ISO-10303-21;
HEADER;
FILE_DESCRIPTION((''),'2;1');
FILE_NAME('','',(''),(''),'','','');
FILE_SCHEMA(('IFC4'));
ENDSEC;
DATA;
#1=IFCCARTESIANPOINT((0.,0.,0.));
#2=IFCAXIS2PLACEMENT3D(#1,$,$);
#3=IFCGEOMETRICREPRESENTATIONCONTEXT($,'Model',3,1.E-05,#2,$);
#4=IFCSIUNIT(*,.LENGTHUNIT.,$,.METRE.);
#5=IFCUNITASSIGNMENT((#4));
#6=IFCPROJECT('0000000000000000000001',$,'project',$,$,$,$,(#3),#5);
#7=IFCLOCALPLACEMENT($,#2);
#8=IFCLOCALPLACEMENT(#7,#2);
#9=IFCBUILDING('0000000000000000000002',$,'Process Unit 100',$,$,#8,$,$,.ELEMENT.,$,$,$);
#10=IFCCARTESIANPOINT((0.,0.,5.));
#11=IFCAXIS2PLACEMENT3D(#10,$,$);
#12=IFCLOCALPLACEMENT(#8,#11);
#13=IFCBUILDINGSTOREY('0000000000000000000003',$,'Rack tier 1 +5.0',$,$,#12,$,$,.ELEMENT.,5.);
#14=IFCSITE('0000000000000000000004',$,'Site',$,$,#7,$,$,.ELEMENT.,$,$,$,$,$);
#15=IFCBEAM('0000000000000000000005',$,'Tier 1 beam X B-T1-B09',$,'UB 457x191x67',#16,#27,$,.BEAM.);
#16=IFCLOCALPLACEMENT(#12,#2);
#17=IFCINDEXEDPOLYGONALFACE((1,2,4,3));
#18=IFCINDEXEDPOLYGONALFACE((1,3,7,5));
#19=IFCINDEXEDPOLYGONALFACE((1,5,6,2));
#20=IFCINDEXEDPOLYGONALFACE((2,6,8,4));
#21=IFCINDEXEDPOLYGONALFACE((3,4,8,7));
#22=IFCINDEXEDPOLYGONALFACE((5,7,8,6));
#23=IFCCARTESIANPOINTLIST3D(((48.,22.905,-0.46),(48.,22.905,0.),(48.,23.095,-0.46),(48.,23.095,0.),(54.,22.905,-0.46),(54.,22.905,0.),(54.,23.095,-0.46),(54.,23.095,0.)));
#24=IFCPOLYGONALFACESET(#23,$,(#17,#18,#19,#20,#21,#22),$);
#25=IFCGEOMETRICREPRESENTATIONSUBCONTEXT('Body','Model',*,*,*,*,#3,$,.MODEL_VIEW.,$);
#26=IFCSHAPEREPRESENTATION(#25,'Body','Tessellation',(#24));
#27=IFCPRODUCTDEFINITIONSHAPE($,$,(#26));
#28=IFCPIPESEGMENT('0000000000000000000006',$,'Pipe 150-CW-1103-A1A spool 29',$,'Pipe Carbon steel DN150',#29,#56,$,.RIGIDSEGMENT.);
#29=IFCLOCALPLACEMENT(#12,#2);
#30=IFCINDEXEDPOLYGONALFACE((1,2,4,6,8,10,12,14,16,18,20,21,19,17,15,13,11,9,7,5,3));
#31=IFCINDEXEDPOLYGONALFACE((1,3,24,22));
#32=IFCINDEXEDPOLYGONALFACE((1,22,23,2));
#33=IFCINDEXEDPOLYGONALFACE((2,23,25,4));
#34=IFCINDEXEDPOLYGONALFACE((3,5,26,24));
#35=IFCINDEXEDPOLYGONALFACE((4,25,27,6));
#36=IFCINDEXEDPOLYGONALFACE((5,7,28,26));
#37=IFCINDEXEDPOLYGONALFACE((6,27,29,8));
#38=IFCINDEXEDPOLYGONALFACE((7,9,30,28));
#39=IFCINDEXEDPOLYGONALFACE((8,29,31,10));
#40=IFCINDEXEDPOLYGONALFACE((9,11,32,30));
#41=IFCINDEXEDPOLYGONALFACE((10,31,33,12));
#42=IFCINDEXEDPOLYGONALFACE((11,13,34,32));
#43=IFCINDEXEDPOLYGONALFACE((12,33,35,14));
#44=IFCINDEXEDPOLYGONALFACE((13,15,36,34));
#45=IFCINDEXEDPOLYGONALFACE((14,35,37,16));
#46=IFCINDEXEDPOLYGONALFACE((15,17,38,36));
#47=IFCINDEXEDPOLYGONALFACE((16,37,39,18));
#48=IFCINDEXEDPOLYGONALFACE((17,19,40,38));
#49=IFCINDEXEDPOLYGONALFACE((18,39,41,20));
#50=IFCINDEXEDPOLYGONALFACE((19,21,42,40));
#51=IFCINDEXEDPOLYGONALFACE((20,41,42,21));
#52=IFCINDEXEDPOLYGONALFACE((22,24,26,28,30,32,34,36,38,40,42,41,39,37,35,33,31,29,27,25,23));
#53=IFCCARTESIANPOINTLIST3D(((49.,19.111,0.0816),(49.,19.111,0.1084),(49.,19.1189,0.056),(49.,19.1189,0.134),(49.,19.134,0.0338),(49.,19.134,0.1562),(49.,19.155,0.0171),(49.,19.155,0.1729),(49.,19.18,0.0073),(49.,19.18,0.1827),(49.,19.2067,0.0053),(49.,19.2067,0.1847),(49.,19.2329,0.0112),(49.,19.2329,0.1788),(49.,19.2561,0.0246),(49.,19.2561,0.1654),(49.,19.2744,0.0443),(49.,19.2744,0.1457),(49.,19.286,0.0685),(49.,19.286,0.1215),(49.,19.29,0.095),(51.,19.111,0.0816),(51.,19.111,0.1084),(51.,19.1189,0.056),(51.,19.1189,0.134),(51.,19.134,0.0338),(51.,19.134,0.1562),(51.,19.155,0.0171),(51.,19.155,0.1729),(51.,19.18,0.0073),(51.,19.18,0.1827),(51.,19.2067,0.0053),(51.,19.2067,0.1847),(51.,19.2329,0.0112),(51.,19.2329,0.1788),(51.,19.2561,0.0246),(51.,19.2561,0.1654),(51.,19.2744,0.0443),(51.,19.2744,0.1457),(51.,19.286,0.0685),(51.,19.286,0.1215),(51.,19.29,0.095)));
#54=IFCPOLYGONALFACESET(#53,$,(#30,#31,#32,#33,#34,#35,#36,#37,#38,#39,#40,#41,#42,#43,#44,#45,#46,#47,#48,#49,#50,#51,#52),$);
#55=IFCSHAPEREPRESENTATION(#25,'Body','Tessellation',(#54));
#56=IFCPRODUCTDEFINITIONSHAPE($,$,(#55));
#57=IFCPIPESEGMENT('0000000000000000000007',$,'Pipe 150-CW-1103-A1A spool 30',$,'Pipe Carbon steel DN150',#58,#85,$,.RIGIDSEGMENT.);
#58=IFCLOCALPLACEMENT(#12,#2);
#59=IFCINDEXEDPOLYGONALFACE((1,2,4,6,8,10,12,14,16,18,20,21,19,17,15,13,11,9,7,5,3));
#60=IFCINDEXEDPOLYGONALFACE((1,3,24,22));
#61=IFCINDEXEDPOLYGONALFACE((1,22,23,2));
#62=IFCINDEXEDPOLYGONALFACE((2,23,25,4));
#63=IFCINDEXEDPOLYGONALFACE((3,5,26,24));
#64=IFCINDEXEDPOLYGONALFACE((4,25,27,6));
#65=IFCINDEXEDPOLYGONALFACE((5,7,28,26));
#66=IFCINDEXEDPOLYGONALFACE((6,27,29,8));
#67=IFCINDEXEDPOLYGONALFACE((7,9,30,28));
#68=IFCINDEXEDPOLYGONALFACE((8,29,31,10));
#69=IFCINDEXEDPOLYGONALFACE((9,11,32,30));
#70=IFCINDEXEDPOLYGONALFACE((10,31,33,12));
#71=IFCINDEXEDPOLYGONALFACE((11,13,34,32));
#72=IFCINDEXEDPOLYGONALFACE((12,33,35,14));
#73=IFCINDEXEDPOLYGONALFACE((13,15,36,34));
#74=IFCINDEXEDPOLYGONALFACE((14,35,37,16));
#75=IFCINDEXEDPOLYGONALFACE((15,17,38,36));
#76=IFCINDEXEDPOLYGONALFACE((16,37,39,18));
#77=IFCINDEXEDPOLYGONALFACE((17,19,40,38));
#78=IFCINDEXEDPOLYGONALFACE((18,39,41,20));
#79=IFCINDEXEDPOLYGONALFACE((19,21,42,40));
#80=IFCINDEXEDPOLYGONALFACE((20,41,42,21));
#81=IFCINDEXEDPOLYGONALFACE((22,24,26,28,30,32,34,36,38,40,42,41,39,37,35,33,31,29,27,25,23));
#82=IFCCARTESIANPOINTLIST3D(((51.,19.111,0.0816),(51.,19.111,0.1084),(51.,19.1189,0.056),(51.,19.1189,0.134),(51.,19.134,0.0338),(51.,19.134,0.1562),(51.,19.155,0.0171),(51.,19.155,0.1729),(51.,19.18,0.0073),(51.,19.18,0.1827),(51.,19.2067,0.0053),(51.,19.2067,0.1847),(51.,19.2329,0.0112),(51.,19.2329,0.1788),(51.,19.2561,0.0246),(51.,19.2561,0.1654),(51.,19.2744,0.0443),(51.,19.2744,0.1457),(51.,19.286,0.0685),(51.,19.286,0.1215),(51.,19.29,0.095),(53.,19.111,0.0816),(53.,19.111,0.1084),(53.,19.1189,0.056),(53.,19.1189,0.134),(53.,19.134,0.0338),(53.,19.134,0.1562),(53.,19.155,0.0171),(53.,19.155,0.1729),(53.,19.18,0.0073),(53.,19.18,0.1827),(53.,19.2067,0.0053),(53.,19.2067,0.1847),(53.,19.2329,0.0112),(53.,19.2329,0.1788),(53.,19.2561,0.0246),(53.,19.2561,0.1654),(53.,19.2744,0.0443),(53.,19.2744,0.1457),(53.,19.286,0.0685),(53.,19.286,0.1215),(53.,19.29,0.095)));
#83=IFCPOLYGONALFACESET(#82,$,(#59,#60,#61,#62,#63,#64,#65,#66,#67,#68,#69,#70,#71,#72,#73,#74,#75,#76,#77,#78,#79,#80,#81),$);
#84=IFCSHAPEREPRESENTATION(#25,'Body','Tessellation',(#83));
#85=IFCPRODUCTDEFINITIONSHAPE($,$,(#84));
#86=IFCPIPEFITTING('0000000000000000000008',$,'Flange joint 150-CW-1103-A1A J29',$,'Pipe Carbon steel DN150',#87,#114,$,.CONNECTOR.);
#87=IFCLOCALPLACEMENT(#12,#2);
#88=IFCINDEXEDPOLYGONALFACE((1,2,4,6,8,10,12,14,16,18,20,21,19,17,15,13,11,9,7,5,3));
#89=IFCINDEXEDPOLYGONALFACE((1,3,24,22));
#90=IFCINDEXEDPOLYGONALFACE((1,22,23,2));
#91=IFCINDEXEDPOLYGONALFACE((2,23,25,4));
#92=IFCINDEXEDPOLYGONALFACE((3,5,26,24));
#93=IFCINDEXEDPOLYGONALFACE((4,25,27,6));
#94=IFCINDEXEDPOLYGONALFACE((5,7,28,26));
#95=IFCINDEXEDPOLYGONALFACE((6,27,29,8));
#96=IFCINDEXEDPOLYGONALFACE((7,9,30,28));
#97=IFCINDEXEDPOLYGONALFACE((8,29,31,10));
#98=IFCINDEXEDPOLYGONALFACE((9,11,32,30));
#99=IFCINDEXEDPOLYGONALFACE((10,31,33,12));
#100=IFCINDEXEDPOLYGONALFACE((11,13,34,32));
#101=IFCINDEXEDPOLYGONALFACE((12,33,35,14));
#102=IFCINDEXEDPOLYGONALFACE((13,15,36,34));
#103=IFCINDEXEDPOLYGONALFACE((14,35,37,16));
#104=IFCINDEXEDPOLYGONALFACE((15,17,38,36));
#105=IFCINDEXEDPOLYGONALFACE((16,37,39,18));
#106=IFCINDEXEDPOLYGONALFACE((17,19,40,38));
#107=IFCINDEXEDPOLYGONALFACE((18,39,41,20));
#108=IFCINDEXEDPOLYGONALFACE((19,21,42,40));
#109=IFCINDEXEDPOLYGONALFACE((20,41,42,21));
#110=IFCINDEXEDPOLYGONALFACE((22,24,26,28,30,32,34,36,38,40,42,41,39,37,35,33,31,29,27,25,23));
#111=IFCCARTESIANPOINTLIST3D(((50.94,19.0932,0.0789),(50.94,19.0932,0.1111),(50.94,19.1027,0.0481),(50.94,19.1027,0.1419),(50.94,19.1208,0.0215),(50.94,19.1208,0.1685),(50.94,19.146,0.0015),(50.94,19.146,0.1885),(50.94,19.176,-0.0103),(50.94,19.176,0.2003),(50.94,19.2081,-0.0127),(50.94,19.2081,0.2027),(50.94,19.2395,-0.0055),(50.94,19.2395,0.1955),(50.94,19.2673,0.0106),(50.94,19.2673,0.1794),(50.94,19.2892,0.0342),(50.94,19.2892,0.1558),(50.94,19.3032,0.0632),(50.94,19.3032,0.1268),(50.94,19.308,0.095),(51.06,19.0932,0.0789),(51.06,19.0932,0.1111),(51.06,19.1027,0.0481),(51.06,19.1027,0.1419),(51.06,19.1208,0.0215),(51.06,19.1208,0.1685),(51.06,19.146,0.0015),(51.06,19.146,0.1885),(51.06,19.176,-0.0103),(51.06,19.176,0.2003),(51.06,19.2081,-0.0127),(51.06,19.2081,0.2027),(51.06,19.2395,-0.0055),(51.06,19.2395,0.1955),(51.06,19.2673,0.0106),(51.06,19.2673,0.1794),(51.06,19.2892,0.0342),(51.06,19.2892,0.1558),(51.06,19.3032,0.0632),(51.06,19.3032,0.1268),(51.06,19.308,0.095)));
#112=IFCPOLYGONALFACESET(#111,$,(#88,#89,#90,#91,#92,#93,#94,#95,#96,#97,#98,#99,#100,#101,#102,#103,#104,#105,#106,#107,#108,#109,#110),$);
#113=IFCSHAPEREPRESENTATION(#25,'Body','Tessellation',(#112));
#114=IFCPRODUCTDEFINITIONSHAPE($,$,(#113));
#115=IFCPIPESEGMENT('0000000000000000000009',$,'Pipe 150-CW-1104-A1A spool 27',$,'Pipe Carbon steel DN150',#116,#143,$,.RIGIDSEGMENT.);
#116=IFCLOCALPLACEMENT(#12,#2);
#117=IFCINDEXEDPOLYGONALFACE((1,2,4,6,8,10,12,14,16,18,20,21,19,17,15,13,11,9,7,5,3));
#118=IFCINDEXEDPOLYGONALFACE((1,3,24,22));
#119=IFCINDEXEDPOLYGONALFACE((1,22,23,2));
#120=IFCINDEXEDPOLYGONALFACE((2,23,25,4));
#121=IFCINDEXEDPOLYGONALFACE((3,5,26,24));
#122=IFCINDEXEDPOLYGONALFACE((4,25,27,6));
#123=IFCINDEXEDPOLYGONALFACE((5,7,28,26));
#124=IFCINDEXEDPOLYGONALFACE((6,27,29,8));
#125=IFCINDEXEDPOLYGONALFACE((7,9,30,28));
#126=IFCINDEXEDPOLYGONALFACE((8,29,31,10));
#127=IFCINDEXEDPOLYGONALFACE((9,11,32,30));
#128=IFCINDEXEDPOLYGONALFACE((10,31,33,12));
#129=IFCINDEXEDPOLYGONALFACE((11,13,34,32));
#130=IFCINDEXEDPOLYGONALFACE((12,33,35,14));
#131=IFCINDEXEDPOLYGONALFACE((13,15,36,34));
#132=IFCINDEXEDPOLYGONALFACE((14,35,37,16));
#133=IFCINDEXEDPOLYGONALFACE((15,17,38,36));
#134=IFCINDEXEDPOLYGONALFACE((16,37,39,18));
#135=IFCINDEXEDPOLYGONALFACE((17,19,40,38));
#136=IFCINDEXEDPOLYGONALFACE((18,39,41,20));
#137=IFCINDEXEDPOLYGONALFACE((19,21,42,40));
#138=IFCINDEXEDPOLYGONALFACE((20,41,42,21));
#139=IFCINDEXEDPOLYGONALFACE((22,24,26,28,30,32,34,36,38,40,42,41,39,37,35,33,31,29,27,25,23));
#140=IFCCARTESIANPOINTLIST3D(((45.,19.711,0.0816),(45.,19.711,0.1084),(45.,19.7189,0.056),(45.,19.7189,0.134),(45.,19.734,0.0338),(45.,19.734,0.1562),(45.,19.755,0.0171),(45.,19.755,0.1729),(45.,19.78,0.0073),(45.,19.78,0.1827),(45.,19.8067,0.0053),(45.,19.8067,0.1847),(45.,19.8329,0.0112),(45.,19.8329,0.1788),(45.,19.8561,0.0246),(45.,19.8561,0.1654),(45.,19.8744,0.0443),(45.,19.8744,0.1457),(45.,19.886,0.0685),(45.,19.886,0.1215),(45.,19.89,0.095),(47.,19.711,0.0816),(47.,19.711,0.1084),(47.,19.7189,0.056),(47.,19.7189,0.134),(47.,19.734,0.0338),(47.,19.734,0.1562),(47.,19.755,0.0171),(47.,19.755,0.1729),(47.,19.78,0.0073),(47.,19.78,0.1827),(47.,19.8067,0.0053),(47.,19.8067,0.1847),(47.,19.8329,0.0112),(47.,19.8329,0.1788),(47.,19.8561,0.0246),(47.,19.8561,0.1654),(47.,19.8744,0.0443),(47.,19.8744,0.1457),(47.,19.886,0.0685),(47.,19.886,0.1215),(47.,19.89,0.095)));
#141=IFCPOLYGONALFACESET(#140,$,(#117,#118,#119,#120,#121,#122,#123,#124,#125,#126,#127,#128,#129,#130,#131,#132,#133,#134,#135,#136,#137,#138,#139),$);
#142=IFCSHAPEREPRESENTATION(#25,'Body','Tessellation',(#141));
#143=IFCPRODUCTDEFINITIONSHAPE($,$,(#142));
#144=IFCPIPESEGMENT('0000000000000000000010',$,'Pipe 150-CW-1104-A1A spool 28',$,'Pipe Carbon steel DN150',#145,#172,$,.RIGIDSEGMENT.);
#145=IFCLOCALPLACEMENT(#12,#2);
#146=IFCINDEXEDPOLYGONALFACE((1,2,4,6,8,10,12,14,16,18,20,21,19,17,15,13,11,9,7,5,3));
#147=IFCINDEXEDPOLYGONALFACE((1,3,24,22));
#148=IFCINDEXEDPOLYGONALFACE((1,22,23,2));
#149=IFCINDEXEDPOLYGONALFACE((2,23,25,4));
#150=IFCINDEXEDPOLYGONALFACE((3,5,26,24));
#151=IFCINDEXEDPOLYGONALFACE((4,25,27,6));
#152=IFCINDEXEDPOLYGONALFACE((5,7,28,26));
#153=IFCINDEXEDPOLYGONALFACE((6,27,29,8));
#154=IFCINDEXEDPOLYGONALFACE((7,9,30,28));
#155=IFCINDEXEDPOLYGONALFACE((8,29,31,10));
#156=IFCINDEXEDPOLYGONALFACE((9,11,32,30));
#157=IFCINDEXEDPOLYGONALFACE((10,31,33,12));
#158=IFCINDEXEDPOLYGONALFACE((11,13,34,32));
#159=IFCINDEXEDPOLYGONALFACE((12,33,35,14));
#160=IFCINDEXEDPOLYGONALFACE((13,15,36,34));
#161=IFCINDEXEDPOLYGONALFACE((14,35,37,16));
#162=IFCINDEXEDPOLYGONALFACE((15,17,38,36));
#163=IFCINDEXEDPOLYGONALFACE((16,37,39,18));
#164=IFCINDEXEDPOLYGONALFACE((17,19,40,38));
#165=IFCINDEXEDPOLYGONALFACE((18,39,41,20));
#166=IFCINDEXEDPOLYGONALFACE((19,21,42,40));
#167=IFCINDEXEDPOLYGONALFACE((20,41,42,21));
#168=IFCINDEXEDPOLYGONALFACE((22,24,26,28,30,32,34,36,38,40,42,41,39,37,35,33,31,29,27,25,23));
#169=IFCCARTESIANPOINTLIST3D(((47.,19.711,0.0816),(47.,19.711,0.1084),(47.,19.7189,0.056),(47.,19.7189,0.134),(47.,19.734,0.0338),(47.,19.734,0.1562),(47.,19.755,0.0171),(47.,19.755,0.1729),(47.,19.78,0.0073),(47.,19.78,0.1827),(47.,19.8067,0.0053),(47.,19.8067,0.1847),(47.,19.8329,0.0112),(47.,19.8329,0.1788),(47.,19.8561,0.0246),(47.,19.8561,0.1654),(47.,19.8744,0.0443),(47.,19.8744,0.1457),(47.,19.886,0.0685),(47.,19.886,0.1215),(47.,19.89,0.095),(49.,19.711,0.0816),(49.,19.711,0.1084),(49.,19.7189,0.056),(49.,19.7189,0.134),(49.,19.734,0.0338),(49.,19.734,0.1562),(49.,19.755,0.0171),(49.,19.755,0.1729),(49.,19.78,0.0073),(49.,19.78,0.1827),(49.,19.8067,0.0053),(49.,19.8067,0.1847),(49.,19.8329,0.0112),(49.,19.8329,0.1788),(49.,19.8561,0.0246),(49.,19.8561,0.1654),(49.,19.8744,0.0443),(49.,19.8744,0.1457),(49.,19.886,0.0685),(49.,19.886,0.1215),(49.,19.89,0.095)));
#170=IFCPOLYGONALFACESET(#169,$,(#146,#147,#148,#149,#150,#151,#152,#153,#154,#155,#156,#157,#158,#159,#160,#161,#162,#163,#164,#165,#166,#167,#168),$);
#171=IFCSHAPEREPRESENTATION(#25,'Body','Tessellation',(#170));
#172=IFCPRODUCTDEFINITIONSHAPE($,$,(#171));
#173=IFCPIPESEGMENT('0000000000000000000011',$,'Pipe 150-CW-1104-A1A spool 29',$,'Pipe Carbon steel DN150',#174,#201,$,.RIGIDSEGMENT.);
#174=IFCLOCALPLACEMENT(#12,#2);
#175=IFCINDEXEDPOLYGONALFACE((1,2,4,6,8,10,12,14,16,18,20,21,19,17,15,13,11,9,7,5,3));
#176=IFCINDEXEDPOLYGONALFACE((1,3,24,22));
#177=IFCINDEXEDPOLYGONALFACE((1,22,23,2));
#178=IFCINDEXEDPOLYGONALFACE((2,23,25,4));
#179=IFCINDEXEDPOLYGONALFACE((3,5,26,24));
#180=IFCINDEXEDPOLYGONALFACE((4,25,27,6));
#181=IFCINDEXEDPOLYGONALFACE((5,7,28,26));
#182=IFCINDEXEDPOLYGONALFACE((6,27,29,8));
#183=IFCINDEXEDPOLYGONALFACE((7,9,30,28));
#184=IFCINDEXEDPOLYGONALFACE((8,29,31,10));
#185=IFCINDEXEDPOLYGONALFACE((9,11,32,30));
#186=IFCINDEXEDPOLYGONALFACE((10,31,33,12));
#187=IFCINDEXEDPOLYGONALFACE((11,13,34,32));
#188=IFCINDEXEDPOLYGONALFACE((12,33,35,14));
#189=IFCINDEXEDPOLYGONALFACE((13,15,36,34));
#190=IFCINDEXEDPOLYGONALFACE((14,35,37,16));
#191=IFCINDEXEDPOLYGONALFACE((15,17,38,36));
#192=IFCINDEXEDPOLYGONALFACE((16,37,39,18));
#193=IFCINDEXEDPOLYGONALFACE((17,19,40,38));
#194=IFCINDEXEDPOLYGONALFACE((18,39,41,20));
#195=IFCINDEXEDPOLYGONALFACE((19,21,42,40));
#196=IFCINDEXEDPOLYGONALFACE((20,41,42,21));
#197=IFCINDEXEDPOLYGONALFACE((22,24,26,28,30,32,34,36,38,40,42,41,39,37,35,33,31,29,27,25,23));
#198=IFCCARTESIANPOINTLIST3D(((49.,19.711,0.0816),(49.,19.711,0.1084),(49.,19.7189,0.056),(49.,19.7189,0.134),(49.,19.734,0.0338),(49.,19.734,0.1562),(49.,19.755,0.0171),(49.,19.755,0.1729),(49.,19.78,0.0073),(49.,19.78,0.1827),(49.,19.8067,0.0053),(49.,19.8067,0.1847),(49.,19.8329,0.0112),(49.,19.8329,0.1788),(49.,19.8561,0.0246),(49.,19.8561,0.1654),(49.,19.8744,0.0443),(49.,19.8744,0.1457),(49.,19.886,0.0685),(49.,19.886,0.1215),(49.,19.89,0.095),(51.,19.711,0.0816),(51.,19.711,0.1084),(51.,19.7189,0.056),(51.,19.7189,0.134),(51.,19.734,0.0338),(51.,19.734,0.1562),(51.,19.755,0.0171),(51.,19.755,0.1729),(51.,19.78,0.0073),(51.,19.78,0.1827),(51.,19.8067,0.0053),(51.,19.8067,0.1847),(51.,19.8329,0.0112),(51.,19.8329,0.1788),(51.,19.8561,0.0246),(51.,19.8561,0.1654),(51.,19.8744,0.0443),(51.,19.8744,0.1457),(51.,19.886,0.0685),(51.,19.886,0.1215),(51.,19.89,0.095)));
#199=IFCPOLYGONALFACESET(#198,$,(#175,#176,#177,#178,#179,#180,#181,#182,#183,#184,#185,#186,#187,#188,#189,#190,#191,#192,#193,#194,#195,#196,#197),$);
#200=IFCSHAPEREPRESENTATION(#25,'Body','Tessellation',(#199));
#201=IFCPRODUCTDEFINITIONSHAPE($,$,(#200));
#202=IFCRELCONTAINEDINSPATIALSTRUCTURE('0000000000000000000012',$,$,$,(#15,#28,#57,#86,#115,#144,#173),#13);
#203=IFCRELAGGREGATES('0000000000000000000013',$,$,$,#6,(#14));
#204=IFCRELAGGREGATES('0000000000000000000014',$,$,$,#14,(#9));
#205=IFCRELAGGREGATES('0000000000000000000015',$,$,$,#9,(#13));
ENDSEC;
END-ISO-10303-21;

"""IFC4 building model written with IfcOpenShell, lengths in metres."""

from ifc_helpers import new_model, si_unit, frame, origin, place, context, subcontext, project, spatial, rectangle, circle, extrude, element, save


model = new_model("IFC4")

# Units and contexts
model_context = context("Model", 3, precision=1e-05, world=origin())
body_context = subcontext(model_context, "Body", "Model", "MODEL_VIEW")
ifc_project = project(units=[si_unit("LENGTHUNIT", "METRE")], contexts=[model_context])

# Site, building, storey
site_placement = place(None, origin())
site = spatial("IfcSite", under=ifc_project, at=site_placement, Name="Site", CompositionType="ELEMENT")
building_placement = place(site_placement, origin())
building = spatial("IfcBuilding", under=site, at=building_placement, Name="Process Unit 100", CompositionType="ELEMENT")
storey_placement = place(building_placement, frame((0.0, 0.0, 5.0)))
storey = spatial("IfcBuildingStorey", under=building, at=storey_placement, Name="Rack tier 1 +5.0", CompositionType="ELEMENT", Elevation=5.0)

# Beam
beam_placement = place(storey_placement, frame((48.0, 23.0, -0.23), z_axis=(1.0, 0.0, 0.0), x_axis=(0.0, 1.0, 0.0)))
element("IfcBeam", 1, at=beam_placement, inside=storey, Name="Tier 1 beam X B-T1-B09", ObjectType="UB 457x191x67", PredefinedType="BEAM", context=body_context, shape_type="SweptSolid", body=[
    extrude(rectangle(XDim=0.19, YDim=0.46), origin(), (0.0, 0.0, 1.0), 6.0),
])

# Pipe segments
for number, where, z_axis, x_axis, name in (
    (2, (49.0, 19.2, 0.095), (1.0, 0.0, 0.0), (0.0, 1.0, 0.0), "Pipe 150-CW-1103-A1A spool 29"),
    (3, (51.0, 19.2, 0.095), (1.0, 0.0, 0.0), (0.0, 1.0, 0.0), "Pipe 150-CW-1103-A1A spool 30"),
):
    element("IfcPipeSegment", number, at=place(storey_placement, frame(where, z_axis=z_axis, x_axis=x_axis)), inside=storey, Name=name, ObjectType="Pipe Carbon steel DN150", PredefinedType="RIGIDSEGMENT", context=body_context, shape_type="SweptSolid", body=[
        extrude(circle(Radius=0.09), origin(), (0.0, 0.0, 1.0), 2.0),
    ])

# Pipe fitting
pipe_fitting_placement = place(storey_placement, frame((50.94, 19.2, 0.095), z_axis=(1.0, 0.0, 0.0), x_axis=(0.0, 1.0, 0.0)))
element("IfcPipeFitting", 4, at=pipe_fitting_placement, inside=storey, Name="Flange joint 150-CW-1103-A1A J29", ObjectType="Pipe Carbon steel DN150", PredefinedType="CONNECTOR", context=body_context, shape_type="SweptSolid", body=[
    extrude(circle(Radius=0.108), origin(), (0.0, 0.0, 1.0), 0.12),
])

# Pipe segments
for number, where, z_axis, x_axis, name in (
    (5, (45.0, 19.8, 0.095), (1.0, 0.0, 0.0), (0.0, 1.0, 0.0), "Pipe 150-CW-1104-A1A spool 27"),
    (6, (47.0, 19.8, 0.095), (1.0, 0.0, 0.0), (0.0, 1.0, 0.0), "Pipe 150-CW-1104-A1A spool 28"),
    (7, (49.0, 19.8, 0.095), (1.0, 0.0, 0.0), (0.0, 1.0, 0.0), "Pipe 150-CW-1104-A1A spool 29"),
):
    element("IfcPipeSegment", number, at=place(storey_placement, frame(where, z_axis=z_axis, x_axis=x_axis)), inside=storey, Name=name, ObjectType="Pipe Carbon steel DN150", PredefinedType="RIGIDSEGMENT", context=body_context, shape_type="SweptSolid", body=[
        extrude(circle(Radius=0.09), origin(), (0.0, 0.0, 1.0), 2.0),
    ])

save(model, "model.ifc")
